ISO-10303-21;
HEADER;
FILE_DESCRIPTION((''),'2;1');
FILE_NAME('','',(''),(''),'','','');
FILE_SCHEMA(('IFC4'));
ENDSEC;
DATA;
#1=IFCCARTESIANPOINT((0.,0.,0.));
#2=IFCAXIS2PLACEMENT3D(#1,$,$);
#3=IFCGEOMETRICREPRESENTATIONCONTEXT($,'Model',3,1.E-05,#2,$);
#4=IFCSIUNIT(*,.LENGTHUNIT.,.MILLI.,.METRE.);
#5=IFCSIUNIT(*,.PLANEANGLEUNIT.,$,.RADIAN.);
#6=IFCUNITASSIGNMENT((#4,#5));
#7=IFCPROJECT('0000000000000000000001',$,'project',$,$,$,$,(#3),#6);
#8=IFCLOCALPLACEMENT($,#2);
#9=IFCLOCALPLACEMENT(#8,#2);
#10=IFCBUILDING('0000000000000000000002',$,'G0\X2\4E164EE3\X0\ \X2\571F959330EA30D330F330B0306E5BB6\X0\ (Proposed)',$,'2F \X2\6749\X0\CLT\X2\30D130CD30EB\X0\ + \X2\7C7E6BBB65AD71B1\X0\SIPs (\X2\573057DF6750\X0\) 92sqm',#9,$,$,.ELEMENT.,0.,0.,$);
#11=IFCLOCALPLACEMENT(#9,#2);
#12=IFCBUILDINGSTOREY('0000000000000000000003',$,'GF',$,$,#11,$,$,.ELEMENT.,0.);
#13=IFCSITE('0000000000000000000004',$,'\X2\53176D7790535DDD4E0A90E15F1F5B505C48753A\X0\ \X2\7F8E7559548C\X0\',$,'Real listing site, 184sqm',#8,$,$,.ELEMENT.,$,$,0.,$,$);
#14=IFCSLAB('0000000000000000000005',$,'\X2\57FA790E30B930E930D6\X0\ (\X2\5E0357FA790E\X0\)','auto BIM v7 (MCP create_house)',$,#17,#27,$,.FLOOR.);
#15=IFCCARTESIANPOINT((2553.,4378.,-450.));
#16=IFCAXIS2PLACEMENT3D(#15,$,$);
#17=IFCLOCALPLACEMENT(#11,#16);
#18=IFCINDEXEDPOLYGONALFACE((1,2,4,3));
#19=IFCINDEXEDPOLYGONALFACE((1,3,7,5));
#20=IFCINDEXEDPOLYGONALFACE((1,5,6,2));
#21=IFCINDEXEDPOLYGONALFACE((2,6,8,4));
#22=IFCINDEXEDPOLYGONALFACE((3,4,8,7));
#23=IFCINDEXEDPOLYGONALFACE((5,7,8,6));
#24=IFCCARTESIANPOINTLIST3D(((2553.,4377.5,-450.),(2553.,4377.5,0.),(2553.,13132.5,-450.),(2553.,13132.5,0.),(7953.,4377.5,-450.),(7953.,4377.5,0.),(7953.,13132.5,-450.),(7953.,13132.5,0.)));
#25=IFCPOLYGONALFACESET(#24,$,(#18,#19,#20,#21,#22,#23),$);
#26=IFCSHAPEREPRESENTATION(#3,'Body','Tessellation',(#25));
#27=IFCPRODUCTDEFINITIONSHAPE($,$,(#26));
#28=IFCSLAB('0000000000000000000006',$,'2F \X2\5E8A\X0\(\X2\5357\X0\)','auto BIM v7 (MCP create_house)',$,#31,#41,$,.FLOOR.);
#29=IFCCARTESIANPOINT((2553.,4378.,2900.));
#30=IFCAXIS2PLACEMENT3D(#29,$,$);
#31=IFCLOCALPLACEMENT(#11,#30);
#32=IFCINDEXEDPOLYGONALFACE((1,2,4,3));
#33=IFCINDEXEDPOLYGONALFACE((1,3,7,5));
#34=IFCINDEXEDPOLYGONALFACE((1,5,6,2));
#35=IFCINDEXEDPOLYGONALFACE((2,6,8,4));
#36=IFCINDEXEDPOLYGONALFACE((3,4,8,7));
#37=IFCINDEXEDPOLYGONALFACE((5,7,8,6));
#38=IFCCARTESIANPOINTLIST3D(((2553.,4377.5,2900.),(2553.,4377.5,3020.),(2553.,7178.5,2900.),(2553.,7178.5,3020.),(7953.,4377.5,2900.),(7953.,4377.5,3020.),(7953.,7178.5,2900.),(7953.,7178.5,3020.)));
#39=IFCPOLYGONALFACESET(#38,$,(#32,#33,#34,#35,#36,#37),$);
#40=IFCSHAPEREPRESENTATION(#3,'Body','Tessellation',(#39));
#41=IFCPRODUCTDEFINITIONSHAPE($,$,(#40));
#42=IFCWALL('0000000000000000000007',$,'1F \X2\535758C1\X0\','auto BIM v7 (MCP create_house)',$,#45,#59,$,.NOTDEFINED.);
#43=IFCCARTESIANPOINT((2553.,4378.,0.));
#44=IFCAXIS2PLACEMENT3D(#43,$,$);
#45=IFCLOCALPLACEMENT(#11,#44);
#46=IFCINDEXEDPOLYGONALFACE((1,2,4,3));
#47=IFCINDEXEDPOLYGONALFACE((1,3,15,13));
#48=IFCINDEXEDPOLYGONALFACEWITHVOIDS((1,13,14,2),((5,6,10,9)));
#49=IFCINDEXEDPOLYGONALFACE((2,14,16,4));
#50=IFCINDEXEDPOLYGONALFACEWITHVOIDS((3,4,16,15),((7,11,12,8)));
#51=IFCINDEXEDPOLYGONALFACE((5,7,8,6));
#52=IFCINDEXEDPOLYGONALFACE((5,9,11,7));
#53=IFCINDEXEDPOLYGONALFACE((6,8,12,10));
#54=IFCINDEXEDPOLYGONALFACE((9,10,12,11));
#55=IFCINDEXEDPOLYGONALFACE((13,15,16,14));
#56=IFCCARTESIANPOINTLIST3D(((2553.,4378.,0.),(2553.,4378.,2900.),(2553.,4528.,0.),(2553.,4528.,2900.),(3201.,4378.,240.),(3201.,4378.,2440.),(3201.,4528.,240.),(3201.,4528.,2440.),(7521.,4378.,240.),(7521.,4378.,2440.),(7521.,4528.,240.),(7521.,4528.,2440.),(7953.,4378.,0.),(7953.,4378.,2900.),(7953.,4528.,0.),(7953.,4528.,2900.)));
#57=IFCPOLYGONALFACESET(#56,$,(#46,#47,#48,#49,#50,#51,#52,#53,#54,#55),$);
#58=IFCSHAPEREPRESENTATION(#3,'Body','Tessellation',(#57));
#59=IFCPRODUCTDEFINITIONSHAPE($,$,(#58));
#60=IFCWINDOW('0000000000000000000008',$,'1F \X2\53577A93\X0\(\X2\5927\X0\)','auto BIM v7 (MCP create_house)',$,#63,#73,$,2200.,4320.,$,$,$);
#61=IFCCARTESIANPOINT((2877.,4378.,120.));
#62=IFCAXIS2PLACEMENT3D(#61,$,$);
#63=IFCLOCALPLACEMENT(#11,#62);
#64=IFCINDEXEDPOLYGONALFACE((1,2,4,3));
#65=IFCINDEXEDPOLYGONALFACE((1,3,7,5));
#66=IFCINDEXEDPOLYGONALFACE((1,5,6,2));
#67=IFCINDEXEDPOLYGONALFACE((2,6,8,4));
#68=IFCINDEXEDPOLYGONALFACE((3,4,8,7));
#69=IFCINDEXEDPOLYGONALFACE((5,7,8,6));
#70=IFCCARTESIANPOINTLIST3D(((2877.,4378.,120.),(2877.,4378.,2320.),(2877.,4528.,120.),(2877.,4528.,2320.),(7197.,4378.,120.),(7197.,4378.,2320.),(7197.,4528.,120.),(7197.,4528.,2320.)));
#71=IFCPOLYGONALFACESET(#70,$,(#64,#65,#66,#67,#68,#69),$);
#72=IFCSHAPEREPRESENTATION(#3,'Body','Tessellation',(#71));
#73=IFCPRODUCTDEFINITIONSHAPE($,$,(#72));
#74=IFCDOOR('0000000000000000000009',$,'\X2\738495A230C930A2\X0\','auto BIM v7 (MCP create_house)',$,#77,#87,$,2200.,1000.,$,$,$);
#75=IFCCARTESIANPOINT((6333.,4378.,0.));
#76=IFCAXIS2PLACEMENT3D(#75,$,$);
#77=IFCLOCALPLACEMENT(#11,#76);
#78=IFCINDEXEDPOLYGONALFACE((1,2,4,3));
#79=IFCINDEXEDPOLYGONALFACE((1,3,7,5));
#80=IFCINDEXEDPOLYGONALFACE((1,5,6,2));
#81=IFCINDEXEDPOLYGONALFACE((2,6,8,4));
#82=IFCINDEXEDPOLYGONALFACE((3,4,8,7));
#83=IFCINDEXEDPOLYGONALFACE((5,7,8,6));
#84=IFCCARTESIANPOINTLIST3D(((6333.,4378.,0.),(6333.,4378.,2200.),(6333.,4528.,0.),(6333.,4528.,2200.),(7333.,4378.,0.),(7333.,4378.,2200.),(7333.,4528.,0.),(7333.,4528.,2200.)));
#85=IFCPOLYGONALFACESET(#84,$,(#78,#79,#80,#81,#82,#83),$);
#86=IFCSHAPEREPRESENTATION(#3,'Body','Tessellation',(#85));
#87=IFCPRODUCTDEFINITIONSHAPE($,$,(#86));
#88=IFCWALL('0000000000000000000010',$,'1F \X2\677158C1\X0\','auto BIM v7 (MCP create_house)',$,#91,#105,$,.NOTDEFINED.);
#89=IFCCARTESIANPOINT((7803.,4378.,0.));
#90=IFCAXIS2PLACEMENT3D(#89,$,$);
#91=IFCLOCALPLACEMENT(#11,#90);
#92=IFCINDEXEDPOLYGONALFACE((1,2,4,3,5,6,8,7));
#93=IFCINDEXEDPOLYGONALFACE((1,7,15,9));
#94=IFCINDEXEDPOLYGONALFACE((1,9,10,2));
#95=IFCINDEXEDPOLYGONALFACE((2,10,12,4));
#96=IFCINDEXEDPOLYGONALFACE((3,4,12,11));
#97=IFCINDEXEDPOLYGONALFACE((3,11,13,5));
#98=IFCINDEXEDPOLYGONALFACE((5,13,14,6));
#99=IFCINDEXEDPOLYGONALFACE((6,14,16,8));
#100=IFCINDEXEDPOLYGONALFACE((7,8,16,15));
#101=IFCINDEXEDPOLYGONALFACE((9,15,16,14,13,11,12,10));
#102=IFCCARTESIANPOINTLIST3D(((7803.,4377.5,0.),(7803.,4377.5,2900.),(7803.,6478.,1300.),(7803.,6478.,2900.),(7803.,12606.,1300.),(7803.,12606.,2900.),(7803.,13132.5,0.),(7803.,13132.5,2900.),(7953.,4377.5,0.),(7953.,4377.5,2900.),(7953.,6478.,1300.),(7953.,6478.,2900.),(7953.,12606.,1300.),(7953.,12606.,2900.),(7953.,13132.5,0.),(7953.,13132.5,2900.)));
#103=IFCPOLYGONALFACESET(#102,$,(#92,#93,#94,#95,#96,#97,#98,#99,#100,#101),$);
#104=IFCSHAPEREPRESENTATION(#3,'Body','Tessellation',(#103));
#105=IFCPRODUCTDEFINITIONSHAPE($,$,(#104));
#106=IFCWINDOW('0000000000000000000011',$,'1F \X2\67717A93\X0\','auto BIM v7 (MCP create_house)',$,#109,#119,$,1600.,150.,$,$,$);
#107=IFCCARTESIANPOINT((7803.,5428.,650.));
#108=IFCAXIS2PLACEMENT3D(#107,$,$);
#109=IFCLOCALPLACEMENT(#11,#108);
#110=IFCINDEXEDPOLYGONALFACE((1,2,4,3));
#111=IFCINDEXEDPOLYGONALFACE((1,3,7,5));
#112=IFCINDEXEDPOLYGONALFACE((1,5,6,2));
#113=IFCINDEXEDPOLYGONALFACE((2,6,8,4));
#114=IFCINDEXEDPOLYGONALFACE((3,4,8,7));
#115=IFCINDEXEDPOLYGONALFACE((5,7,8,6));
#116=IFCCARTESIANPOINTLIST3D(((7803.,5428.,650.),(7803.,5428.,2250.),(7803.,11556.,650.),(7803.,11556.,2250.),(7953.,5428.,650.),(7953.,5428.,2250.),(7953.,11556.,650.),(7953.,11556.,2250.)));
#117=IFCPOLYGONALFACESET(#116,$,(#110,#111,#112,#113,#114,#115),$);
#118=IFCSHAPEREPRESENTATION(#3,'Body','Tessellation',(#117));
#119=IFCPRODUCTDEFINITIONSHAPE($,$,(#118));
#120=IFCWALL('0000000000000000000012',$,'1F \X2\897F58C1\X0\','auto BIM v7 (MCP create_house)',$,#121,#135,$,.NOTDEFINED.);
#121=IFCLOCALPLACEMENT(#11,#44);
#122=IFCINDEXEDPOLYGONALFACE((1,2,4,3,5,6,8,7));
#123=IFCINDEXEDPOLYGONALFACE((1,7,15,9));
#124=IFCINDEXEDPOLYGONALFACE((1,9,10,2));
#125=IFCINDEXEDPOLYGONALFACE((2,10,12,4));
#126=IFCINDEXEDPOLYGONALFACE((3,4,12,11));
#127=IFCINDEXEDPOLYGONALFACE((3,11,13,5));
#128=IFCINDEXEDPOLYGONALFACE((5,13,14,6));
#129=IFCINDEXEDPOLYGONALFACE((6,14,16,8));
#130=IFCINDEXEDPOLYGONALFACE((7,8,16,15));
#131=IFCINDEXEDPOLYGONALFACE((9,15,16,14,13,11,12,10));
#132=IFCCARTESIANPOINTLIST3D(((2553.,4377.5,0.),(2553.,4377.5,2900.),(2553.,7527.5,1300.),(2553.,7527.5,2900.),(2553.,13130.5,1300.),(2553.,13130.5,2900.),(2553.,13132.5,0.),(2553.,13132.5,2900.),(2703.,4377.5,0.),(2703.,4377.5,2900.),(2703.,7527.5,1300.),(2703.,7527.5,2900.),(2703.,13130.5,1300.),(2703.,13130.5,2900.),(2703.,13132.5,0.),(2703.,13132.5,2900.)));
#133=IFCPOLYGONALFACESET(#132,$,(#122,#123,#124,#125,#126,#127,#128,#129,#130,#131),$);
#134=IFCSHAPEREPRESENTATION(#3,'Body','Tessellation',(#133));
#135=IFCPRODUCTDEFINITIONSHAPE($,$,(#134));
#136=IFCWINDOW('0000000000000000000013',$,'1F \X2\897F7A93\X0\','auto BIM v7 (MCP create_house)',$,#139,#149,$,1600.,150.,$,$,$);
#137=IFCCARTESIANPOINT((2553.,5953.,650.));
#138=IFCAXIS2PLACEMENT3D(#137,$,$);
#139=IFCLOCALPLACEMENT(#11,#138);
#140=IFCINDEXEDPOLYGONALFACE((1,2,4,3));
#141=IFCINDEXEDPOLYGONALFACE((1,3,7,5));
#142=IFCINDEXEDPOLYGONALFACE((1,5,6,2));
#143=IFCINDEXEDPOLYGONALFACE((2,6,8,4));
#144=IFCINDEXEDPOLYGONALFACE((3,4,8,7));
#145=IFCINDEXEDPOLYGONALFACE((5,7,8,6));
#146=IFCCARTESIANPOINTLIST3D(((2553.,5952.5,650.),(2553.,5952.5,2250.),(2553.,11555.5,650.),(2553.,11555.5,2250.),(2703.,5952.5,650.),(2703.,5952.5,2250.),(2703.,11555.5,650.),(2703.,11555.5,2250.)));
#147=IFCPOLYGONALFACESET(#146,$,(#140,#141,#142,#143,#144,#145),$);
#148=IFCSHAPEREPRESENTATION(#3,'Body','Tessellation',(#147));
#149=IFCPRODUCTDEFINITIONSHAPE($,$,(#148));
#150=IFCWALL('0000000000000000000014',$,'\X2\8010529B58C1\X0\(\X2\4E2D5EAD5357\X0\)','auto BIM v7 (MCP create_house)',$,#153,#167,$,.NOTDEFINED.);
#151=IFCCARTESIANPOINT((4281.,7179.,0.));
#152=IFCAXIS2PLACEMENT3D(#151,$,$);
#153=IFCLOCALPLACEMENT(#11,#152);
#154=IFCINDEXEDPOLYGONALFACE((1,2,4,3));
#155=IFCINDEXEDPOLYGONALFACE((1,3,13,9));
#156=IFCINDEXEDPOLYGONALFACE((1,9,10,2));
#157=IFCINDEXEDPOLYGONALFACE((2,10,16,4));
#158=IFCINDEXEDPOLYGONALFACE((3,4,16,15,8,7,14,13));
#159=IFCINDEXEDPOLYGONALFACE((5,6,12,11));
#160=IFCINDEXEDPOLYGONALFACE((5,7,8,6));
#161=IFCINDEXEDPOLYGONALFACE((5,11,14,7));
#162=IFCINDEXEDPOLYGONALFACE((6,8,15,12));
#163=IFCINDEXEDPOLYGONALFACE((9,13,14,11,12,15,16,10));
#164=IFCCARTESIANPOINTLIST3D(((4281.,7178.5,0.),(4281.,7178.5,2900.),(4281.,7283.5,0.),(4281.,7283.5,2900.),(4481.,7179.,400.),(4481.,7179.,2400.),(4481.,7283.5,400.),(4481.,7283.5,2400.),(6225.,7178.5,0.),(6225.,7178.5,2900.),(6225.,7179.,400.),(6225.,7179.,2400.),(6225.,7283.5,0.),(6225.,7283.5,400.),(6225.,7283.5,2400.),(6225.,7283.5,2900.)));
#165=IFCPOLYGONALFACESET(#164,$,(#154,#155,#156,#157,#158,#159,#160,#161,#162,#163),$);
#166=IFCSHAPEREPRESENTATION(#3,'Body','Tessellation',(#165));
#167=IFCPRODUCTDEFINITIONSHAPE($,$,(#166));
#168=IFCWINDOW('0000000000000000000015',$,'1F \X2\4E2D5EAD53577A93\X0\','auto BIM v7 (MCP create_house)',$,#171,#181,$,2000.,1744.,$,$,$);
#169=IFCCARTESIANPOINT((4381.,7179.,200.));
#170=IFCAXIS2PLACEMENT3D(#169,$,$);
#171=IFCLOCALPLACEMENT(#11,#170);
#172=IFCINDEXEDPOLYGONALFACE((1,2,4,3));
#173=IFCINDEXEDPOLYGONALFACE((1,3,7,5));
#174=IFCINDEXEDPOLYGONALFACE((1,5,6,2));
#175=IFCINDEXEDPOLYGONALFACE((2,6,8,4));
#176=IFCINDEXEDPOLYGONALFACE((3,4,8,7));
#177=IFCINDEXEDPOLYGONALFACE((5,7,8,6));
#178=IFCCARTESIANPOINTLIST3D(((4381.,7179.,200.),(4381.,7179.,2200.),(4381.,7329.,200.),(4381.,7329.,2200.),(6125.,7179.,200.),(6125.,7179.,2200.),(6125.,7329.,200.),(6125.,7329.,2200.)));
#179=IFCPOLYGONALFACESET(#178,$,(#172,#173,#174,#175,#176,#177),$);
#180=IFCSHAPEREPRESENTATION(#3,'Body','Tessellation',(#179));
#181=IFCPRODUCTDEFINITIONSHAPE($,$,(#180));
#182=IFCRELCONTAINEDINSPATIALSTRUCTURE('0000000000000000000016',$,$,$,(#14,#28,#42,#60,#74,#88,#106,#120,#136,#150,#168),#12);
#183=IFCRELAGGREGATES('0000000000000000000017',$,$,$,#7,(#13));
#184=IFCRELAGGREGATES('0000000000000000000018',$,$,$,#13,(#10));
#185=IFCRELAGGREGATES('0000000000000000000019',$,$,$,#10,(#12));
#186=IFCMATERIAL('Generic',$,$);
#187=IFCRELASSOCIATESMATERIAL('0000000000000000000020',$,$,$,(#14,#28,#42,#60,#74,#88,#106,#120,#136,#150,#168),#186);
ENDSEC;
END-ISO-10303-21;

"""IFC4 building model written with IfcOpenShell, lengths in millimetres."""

from ifc_helpers import new_model, si_unit, frame, frame_2d, origin, place, context, project, spatial, rectangle, extrude, material, element, fill, save


model = new_model("IFC4")

# Units and contexts
model_context = context("Model", 3, precision=1e-05, world=origin())
ifc_project = project(units=[si_unit("LENGTHUNIT", "METRE", prefix="MILLI"), si_unit("PLANEANGLEUNIT", "RADIAN")], contexts=[model_context])

# Site, building, storey
site_placement = place(None, origin())
site = spatial("IfcSite", under=ifc_project, at=site_placement, Name="北海道川上郡弟子屈町 美留和", ObjectType="Real listing site, 184sqm", CompositionType="ELEMENT", RefElevation=0.0)
building_placement = place(site_placement, origin())
building = spatial("IfcBuilding", under=site, at=building_placement, Name="G0世代 土間リビングの家 (Proposed)", ObjectType="2F 杉CLTパネル + 籾殻断熱SIPs (地域材) 92sqm", CompositionType="ELEMENT", ElevationOfRefHeight=0.0, ElevationOfTerrain=0.0)
storey_placement = place(building_placement, origin())
storey = spatial("IfcBuildingStorey", under=building, at=storey_placement, Name="GF", CompositionType="ELEMENT", Elevation=0.0)

# Slabs
ifc_material = material(Name="Generic")
slab_1_placement = place(storey_placement, frame((2553.0, 4378.0, -450.0)))
element("IfcSlab", 1, at=slab_1_placement, inside=storey, material=ifc_material, Name="基礎スラブ (布基礎)", Description="auto BIM v7 (MCP create_house)", PredefinedType="FLOOR", context=model_context, shape_type="SweptSolid", body=[
    extrude(rectangle(XDim=5400.0, YDim=8755.0, at=frame_2d((2700.0, 4377.0))), frame((2553.0, 4378.0, -450.0)), (0.0, 0.0, 1.0), 450.0),
])
slab_2_placement = place(storey_placement, frame((2553.0, 4378.0, 2900.0)))
element("IfcSlab", 2, at=slab_2_placement, inside=storey, material=ifc_material, Name="2F 床(南)", Description="auto BIM v7 (MCP create_house)", PredefinedType="FLOOR", context=model_context, shape_type="SweptSolid", body=[
    extrude(rectangle(XDim=5400.0, YDim=2801.0, at=frame_2d((2700.0, 1400.0))), frame((2553.0, 4378.0, 2900.0)), (0.0, 0.0, 1.0), 120.0),
])

# Wall, openings, window, door
wall_1_placement = place(storey_placement, frame((2553.0, 4378.0, 0.0)))
wall_1 = element("IfcWall", 3, at=wall_1_placement, inside=storey, material=ifc_material, Name="1F 南壁", Description="auto BIM v7 (MCP create_house)", PredefinedType="NOTDEFINED", context=model_context, shape_type="SweptSolid", body=[
    extrude(rectangle(XDim=5400.0, YDim=150.0, at=frame_2d((2700.0, 75.0))), frame((2553.0, 4378.0, 0.0)), (0.0, 0.0, 1.0), 2900.0),
])
opening_1_placement = place(storey_placement, frame((2877.0, 4378.0, 120.0)))
opening_1 = element("IfcOpeningElement", 4, at=opening_1_placement, cuts=wall_1, PredefinedType="NOTDEFINED", context=model_context, shape_type="SweptSolid", body=[
    extrude(rectangle(XDim=4320.0, YDim=150.0, at=frame_2d((2160.0, 75.0))), frame((2877.0, 4378.0, 120.0)), (0.0, 0.0, 1.0), 2200.0),
])
opening_2_placement = place(storey_placement, frame((6333.0, 4378.0, 0.0)))
opening_2 = element("IfcOpeningElement", 5, at=opening_2_placement, cuts=wall_1, PredefinedType="NOTDEFINED", context=model_context, shape_type="SweptSolid", body=[
    extrude(rectangle(XDim=1000.0, YDim=150.0, at=frame_2d((500.0, 75.0))), frame((6333.0, 4378.0, 0.0)), (0.0, 0.0, 1.0), 2200.0),
])
window_1_placement = place(storey_placement, frame((2877.0, 4378.0, 120.0)))
window_1 = element("IfcWindow", 6, at=window_1_placement, inside=storey, material=ifc_material, Name="1F 南窓(大)", Description="auto BIM v7 (MCP create_house)", OverallHeight=2200.0, OverallWidth=4320.0, context=model_context, shape_type="SweptSolid", body=[
    extrude(rectangle(XDim=4320.0, YDim=150.0, at=frame_2d((2160.0, 75.0))), frame((2877.0, 4378.0, 120.0)), (0.0, 0.0, 1.0), 2200.0),
])
fill(opening_1, window_1)
door_placement = place(storey_placement, frame((6333.0, 4378.0, 0.0)))
door = element("IfcDoor", 7, at=door_placement, inside=storey, material=ifc_material, Name="玄関ドア", Description="auto BIM v7 (MCP create_house)", OverallHeight=2200.0, OverallWidth=1000.0, context=model_context, shape_type="SweptSolid", body=[
    extrude(rectangle(XDim=1000.0, YDim=150.0, at=frame_2d((500.0, 75.0))), frame((6333.0, 4378.0, 0.0)), (0.0, 0.0, 1.0), 2200.0),
])
fill(opening_2, door)

# Walls, openings, windows
wall_2_placement = place(storey_placement, frame((7803.0, 4378.0, 0.0)))
wall_2 = element("IfcWall", 8, at=wall_2_placement, inside=storey, material=ifc_material, Name="1F 東壁", Description="auto BIM v7 (MCP create_house)", PredefinedType="NOTDEFINED", context=model_context, shape_type="SweptSolid", body=[
    extrude(rectangle(XDim=150.0, YDim=8755.0, at=frame_2d((75.0, 4377.0))), frame((7803.0, 4378.0, 0.0)), (0.0, 0.0, 1.0), 2900.0),
])
opening_3_placement = place(storey_placement, frame((7803.0, 5428.0, 650.0)))
opening_3 = element("IfcOpeningElement", 9, at=opening_3_placement, cuts=wall_2, PredefinedType="NOTDEFINED", context=model_context, shape_type="SweptSolid", body=[
    extrude(rectangle(XDim=150.0, YDim=6128.0, at=frame_2d((75.0, 3064.0))), frame((7803.0, 5428.0, 650.0)), (0.0, 0.0, 1.0), 1600.0),
])
window_2_placement = place(storey_placement, frame((7803.0, 5428.0, 650.0)))
window_2 = element("IfcWindow", 10, at=window_2_placement, inside=storey, material=ifc_material, Name="1F 東窓", Description="auto BIM v7 (MCP create_house)", OverallHeight=1600.0, OverallWidth=150.0, context=model_context, shape_type="SweptSolid", body=[
    extrude(rectangle(XDim=150.0, YDim=6128.0, at=frame_2d((75.0, 3064.0))), frame((7803.0, 5428.0, 650.0)), (0.0, 0.0, 1.0), 1600.0),
])
fill(opening_3, window_2)
wall_3_placement = place(storey_placement, frame((2553.0, 4378.0, 0.0)))
wall_3 = element("IfcWall", 11, at=wall_3_placement, inside=storey, material=ifc_material, Name="1F 西壁", Description="auto BIM v7 (MCP create_house)", PredefinedType="NOTDEFINED", context=model_context, shape_type="SweptSolid", body=[
    extrude(rectangle(XDim=150.0, YDim=8755.0, at=frame_2d((75.0, 4377.0))), frame((2553.0, 4378.0, 0.0)), (0.0, 0.0, 1.0), 2900.0),
])
opening_4_placement = place(storey_placement, frame((2553.0, 5953.0, 650.0)))
opening_4 = element("IfcOpeningElement", 12, at=opening_4_placement, cuts=wall_3, PredefinedType="NOTDEFINED", context=model_context, shape_type="SweptSolid", body=[
    extrude(rectangle(XDim=150.0, YDim=5603.0, at=frame_2d((75.0, 2801.0))), frame((2553.0, 5953.0, 650.0)), (0.0, 0.0, 1.0), 1600.0),
])
window_3_placement = place(storey_placement, frame((2553.0, 5953.0, 650.0)))
window_3 = element("IfcWindow", 13, at=window_3_placement, inside=storey, material=ifc_material, Name="1F 西窓", Description="auto BIM v7 (MCP create_house)", OverallHeight=1600.0, OverallWidth=150.0, context=model_context, shape_type="SweptSolid", body=[
    extrude(rectangle(XDim=150.0, YDim=5603.0, at=frame_2d((75.0, 2801.0))), frame((2553.0, 5953.0, 650.0)), (0.0, 0.0, 1.0), 1600.0),
])
fill(opening_4, window_3)
wall_4_placement = place(storey_placement, frame((4281.0, 7179.0, 0.0)))
wall_4 = element("IfcWall", 14, at=wall_4_placement, inside=storey, material=ifc_material, Name="耐力壁(中庭南)", Description="auto BIM v7 (MCP create_house)", PredefinedType="NOTDEFINED", context=model_context, shape_type="SweptSolid", body=[
    extrude(rectangle(XDim=1944.0, YDim=105.0, at=frame_2d((972.0, 52.0))), frame((4281.0, 7179.0, 0.0)), (0.0, 0.0, 1.0), 2900.0),
])
opening_5_placement = place(storey_placement, frame((4381.0, 7179.0, 200.0)))
opening_5 = element("IfcOpeningElement", 15, at=opening_5_placement, cuts=wall_4, PredefinedType="NOTDEFINED", context=model_context, shape_type="SweptSolid", body=[
    extrude(rectangle(XDim=1744.0, YDim=150.0, at=frame_2d((872.0, 75.0))), frame((4381.0, 7179.0, 200.0)), (0.0, 0.0, 1.0), 2000.0),
])
window_4_placement = place(storey_placement, frame((4381.0, 7179.0, 200.0)))
window_4 = element("IfcWindow", 16, at=window_4_placement, inside=storey, material=ifc_material, Name="1F 中庭南窓", Description="auto BIM v7 (MCP create_house)", OverallHeight=2000.0, OverallWidth=1744.0, context=model_context, shape_type="SweptSolid", body=[
    extrude(rectangle(XDim=1744.0, YDim=150.0, at=frame_2d((872.0, 75.0))), frame((4381.0, 7179.0, 200.0)), (0.0, 0.0, 1.0), 2000.0),
])
fill(opening_5, window_4)

save(model, "model.ifc")
